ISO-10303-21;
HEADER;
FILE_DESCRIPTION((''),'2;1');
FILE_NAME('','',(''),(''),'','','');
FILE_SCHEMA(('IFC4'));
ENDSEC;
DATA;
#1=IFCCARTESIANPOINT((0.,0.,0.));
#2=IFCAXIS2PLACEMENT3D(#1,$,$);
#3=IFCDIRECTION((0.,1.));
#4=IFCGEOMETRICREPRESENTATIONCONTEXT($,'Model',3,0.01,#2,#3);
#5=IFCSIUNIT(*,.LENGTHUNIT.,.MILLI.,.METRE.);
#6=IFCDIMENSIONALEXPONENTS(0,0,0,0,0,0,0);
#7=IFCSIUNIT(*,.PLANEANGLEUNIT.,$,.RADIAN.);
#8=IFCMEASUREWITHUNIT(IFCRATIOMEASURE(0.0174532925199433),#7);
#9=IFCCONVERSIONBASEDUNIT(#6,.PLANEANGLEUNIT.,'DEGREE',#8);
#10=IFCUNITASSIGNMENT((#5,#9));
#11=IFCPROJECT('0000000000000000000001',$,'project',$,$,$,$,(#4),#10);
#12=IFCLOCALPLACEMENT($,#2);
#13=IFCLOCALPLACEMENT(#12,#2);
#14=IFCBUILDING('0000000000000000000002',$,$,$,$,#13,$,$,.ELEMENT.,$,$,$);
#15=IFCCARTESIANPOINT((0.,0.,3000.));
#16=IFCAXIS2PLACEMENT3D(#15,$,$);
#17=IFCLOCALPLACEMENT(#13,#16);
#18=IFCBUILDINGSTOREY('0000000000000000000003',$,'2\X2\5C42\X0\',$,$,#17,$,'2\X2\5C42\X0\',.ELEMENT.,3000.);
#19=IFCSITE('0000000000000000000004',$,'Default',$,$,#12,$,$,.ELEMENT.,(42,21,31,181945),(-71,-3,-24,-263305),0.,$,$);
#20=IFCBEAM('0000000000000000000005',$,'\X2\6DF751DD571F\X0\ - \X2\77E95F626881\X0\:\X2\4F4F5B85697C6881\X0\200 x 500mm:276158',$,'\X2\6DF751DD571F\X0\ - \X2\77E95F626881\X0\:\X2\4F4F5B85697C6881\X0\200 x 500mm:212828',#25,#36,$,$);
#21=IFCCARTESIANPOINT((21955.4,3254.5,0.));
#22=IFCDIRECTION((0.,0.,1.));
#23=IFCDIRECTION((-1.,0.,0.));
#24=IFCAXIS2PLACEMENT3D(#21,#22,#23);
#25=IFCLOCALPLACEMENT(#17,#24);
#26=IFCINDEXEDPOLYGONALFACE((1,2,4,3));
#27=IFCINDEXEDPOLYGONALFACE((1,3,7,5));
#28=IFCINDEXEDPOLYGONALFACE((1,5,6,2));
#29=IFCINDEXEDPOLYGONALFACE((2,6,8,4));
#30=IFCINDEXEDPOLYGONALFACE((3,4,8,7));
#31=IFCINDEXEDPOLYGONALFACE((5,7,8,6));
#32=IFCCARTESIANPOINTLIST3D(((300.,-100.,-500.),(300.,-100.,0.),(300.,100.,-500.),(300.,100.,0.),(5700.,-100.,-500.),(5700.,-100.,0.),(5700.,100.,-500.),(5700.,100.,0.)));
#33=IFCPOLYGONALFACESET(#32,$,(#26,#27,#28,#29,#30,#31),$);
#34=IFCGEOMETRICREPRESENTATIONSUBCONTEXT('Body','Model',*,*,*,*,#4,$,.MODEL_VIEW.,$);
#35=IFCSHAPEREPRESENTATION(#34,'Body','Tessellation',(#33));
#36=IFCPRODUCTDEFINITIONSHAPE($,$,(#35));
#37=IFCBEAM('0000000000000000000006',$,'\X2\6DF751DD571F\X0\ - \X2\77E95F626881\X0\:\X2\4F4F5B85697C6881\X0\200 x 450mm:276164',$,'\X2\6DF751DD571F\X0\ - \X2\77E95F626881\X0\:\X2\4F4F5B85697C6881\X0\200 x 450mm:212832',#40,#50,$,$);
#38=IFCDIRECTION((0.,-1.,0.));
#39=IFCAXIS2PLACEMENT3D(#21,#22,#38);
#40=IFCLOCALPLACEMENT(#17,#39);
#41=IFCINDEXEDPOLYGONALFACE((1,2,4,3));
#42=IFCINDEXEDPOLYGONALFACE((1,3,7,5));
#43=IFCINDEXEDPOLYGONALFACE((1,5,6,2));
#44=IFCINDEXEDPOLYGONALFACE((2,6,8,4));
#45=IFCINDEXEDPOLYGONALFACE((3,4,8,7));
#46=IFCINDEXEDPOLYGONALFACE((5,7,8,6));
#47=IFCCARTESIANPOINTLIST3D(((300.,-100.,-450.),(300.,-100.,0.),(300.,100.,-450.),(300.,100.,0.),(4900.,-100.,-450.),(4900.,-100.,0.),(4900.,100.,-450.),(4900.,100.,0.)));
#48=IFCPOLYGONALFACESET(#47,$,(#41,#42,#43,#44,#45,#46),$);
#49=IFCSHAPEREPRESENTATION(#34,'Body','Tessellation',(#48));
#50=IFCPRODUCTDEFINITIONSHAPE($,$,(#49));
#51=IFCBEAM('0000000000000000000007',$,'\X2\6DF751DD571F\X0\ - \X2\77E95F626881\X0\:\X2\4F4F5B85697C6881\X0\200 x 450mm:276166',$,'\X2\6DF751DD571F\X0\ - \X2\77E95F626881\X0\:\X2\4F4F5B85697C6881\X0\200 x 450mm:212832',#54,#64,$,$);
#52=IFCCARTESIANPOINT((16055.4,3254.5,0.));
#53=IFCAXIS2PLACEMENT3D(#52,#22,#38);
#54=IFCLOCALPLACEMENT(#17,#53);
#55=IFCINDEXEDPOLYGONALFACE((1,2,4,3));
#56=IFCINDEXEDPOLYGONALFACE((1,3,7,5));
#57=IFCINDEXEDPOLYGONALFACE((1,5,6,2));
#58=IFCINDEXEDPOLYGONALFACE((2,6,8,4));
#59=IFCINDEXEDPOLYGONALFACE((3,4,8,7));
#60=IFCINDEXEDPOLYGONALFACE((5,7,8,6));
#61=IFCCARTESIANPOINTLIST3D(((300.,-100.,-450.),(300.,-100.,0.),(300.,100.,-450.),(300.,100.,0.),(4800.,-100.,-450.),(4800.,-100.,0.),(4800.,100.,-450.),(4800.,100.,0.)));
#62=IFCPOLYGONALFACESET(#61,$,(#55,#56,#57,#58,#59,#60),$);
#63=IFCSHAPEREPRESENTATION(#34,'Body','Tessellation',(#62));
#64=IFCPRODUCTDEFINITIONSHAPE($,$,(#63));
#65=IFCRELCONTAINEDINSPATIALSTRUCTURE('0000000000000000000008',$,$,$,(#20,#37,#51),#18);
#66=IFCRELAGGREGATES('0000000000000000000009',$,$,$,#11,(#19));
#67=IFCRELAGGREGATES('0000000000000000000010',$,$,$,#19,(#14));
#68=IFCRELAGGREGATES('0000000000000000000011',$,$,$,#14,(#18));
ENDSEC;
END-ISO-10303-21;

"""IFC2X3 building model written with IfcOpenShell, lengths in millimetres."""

from ifc_helpers import new_model, entity, si_unit, converted_unit, direction, frame, frame_2d, origin, place, context, subcontext, project, spatial, rectangle, extrude, element, save


model = new_model("IFC2X3")

# Units and contexts
model_context = context("Model", 3, precision=0.01, world=origin(), true_north=direction((0.0, 1.0)))
body_context = subcontext(model_context, "Body", "Model", "MODEL_VIEW")
ifc_project = project(units=[si_unit("LENGTHUNIT", "METRE", prefix="MILLI"), converted_unit("PLANEANGLEUNIT", "DEGREE", entity("IfcRatioMeasure", 0.0174532925199433), si_unit("PLANEANGLEUNIT", "RADIAN"), dimensions=[0, 0, 0, 0, 0, 0, 0])], contexts=[model_context])

# Site, building, storey
site_placement = place(None, origin())
site = spatial("IfcSite", under=ifc_project, at=site_placement, Name="Default", CompositionType="ELEMENT", RefLatitude=(42, 21, 31, 181945), RefLongitude=(-71, -3, -24, -263305), RefElevation=0.0)
building_placement = place(site_placement, origin())
building = spatial("IfcBuilding", under=site, at=building_placement, CompositionType="ELEMENT")
storey_placement = place(building_placement, frame((0.0, 0.0, 3000.0)))
storey = spatial("IfcBuildingStorey", under=building, at=storey_placement, Name="2层", LongName="2层", CompositionType="ELEMENT", Elevation=3000.0)

# Beams
beam_1_placement = place(storey_placement, frame((21955.4, 3254.5, 0.0), z_axis=(0.0, 0.0, 1.0), x_axis=(-1.0, 0.0, 0.0)))
element("IfcBeam", 1, at=beam_1_placement, inside=storey, Name="混凝土 - 矩形梁:住宅楼梁200 x 500mm:276158", ObjectType="混凝土 - 矩形梁:住宅楼梁200 x 500mm:212828", context=body_context, shape_type="SweptSolid", body=[
    extrude(rectangle(XDim=500.0, YDim=200.0, at=frame_2d((0.0, 0.0), x_axis=(1.0, 0.0))), frame((300.0, 0.0, -250.0), z_axis=(1.0, 0.0, 0.0), x_axis=(0.0, 0.0, -1.0)), (0.0, 0.0, 1.0), 5400.0),
])
beam_2_placement = place(storey_placement, frame((21955.4, 3254.5, 0.0), z_axis=(0.0, 0.0, 1.0), x_axis=(0.0, -1.0, 0.0)))
element("IfcBeam", 2, at=beam_2_placement, inside=storey, Name="混凝土 - 矩形梁:住宅楼梁200 x 450mm:276164", ObjectType="混凝土 - 矩形梁:住宅楼梁200 x 450mm:212832", context=body_context, shape_type="SweptSolid", body=[
    extrude(rectangle(XDim=450.0, YDim=200.0, at=frame_2d((0.0, 0.0), x_axis=(1.0, 0.0))), frame((300.0, 0.0, -225.0), z_axis=(1.0, 0.0, 0.0), x_axis=(0.0, 0.0, -1.0)), (0.0, 0.0, 1.0), 4600.0),
])
beam_3_placement = place(storey_placement, frame((16055.4, 3254.5, 0.0), z_axis=(0.0, 0.0, 1.0), x_axis=(0.0, -1.0, 0.0)))
element("IfcBeam", 3, at=beam_3_placement, inside=storey, Name="混凝土 - 矩形梁:住宅楼梁200 x 450mm:276166", ObjectType="混凝土 - 矩形梁:住宅楼梁200 x 450mm:212832", context=body_context, shape_type="SweptSolid", body=[
    extrude(rectangle(XDim=450.0, YDim=200.0, at=frame_2d((0.0, 0.0), x_axis=(1.0, 0.0))), frame((300.0, 0.0, -225.0), z_axis=(1.0, 0.0, 0.0), x_axis=(0.0, 0.0, -1.0)), (0.0, 0.0, 1.0), 4500.0),
])

save(model, "model.ifc")
